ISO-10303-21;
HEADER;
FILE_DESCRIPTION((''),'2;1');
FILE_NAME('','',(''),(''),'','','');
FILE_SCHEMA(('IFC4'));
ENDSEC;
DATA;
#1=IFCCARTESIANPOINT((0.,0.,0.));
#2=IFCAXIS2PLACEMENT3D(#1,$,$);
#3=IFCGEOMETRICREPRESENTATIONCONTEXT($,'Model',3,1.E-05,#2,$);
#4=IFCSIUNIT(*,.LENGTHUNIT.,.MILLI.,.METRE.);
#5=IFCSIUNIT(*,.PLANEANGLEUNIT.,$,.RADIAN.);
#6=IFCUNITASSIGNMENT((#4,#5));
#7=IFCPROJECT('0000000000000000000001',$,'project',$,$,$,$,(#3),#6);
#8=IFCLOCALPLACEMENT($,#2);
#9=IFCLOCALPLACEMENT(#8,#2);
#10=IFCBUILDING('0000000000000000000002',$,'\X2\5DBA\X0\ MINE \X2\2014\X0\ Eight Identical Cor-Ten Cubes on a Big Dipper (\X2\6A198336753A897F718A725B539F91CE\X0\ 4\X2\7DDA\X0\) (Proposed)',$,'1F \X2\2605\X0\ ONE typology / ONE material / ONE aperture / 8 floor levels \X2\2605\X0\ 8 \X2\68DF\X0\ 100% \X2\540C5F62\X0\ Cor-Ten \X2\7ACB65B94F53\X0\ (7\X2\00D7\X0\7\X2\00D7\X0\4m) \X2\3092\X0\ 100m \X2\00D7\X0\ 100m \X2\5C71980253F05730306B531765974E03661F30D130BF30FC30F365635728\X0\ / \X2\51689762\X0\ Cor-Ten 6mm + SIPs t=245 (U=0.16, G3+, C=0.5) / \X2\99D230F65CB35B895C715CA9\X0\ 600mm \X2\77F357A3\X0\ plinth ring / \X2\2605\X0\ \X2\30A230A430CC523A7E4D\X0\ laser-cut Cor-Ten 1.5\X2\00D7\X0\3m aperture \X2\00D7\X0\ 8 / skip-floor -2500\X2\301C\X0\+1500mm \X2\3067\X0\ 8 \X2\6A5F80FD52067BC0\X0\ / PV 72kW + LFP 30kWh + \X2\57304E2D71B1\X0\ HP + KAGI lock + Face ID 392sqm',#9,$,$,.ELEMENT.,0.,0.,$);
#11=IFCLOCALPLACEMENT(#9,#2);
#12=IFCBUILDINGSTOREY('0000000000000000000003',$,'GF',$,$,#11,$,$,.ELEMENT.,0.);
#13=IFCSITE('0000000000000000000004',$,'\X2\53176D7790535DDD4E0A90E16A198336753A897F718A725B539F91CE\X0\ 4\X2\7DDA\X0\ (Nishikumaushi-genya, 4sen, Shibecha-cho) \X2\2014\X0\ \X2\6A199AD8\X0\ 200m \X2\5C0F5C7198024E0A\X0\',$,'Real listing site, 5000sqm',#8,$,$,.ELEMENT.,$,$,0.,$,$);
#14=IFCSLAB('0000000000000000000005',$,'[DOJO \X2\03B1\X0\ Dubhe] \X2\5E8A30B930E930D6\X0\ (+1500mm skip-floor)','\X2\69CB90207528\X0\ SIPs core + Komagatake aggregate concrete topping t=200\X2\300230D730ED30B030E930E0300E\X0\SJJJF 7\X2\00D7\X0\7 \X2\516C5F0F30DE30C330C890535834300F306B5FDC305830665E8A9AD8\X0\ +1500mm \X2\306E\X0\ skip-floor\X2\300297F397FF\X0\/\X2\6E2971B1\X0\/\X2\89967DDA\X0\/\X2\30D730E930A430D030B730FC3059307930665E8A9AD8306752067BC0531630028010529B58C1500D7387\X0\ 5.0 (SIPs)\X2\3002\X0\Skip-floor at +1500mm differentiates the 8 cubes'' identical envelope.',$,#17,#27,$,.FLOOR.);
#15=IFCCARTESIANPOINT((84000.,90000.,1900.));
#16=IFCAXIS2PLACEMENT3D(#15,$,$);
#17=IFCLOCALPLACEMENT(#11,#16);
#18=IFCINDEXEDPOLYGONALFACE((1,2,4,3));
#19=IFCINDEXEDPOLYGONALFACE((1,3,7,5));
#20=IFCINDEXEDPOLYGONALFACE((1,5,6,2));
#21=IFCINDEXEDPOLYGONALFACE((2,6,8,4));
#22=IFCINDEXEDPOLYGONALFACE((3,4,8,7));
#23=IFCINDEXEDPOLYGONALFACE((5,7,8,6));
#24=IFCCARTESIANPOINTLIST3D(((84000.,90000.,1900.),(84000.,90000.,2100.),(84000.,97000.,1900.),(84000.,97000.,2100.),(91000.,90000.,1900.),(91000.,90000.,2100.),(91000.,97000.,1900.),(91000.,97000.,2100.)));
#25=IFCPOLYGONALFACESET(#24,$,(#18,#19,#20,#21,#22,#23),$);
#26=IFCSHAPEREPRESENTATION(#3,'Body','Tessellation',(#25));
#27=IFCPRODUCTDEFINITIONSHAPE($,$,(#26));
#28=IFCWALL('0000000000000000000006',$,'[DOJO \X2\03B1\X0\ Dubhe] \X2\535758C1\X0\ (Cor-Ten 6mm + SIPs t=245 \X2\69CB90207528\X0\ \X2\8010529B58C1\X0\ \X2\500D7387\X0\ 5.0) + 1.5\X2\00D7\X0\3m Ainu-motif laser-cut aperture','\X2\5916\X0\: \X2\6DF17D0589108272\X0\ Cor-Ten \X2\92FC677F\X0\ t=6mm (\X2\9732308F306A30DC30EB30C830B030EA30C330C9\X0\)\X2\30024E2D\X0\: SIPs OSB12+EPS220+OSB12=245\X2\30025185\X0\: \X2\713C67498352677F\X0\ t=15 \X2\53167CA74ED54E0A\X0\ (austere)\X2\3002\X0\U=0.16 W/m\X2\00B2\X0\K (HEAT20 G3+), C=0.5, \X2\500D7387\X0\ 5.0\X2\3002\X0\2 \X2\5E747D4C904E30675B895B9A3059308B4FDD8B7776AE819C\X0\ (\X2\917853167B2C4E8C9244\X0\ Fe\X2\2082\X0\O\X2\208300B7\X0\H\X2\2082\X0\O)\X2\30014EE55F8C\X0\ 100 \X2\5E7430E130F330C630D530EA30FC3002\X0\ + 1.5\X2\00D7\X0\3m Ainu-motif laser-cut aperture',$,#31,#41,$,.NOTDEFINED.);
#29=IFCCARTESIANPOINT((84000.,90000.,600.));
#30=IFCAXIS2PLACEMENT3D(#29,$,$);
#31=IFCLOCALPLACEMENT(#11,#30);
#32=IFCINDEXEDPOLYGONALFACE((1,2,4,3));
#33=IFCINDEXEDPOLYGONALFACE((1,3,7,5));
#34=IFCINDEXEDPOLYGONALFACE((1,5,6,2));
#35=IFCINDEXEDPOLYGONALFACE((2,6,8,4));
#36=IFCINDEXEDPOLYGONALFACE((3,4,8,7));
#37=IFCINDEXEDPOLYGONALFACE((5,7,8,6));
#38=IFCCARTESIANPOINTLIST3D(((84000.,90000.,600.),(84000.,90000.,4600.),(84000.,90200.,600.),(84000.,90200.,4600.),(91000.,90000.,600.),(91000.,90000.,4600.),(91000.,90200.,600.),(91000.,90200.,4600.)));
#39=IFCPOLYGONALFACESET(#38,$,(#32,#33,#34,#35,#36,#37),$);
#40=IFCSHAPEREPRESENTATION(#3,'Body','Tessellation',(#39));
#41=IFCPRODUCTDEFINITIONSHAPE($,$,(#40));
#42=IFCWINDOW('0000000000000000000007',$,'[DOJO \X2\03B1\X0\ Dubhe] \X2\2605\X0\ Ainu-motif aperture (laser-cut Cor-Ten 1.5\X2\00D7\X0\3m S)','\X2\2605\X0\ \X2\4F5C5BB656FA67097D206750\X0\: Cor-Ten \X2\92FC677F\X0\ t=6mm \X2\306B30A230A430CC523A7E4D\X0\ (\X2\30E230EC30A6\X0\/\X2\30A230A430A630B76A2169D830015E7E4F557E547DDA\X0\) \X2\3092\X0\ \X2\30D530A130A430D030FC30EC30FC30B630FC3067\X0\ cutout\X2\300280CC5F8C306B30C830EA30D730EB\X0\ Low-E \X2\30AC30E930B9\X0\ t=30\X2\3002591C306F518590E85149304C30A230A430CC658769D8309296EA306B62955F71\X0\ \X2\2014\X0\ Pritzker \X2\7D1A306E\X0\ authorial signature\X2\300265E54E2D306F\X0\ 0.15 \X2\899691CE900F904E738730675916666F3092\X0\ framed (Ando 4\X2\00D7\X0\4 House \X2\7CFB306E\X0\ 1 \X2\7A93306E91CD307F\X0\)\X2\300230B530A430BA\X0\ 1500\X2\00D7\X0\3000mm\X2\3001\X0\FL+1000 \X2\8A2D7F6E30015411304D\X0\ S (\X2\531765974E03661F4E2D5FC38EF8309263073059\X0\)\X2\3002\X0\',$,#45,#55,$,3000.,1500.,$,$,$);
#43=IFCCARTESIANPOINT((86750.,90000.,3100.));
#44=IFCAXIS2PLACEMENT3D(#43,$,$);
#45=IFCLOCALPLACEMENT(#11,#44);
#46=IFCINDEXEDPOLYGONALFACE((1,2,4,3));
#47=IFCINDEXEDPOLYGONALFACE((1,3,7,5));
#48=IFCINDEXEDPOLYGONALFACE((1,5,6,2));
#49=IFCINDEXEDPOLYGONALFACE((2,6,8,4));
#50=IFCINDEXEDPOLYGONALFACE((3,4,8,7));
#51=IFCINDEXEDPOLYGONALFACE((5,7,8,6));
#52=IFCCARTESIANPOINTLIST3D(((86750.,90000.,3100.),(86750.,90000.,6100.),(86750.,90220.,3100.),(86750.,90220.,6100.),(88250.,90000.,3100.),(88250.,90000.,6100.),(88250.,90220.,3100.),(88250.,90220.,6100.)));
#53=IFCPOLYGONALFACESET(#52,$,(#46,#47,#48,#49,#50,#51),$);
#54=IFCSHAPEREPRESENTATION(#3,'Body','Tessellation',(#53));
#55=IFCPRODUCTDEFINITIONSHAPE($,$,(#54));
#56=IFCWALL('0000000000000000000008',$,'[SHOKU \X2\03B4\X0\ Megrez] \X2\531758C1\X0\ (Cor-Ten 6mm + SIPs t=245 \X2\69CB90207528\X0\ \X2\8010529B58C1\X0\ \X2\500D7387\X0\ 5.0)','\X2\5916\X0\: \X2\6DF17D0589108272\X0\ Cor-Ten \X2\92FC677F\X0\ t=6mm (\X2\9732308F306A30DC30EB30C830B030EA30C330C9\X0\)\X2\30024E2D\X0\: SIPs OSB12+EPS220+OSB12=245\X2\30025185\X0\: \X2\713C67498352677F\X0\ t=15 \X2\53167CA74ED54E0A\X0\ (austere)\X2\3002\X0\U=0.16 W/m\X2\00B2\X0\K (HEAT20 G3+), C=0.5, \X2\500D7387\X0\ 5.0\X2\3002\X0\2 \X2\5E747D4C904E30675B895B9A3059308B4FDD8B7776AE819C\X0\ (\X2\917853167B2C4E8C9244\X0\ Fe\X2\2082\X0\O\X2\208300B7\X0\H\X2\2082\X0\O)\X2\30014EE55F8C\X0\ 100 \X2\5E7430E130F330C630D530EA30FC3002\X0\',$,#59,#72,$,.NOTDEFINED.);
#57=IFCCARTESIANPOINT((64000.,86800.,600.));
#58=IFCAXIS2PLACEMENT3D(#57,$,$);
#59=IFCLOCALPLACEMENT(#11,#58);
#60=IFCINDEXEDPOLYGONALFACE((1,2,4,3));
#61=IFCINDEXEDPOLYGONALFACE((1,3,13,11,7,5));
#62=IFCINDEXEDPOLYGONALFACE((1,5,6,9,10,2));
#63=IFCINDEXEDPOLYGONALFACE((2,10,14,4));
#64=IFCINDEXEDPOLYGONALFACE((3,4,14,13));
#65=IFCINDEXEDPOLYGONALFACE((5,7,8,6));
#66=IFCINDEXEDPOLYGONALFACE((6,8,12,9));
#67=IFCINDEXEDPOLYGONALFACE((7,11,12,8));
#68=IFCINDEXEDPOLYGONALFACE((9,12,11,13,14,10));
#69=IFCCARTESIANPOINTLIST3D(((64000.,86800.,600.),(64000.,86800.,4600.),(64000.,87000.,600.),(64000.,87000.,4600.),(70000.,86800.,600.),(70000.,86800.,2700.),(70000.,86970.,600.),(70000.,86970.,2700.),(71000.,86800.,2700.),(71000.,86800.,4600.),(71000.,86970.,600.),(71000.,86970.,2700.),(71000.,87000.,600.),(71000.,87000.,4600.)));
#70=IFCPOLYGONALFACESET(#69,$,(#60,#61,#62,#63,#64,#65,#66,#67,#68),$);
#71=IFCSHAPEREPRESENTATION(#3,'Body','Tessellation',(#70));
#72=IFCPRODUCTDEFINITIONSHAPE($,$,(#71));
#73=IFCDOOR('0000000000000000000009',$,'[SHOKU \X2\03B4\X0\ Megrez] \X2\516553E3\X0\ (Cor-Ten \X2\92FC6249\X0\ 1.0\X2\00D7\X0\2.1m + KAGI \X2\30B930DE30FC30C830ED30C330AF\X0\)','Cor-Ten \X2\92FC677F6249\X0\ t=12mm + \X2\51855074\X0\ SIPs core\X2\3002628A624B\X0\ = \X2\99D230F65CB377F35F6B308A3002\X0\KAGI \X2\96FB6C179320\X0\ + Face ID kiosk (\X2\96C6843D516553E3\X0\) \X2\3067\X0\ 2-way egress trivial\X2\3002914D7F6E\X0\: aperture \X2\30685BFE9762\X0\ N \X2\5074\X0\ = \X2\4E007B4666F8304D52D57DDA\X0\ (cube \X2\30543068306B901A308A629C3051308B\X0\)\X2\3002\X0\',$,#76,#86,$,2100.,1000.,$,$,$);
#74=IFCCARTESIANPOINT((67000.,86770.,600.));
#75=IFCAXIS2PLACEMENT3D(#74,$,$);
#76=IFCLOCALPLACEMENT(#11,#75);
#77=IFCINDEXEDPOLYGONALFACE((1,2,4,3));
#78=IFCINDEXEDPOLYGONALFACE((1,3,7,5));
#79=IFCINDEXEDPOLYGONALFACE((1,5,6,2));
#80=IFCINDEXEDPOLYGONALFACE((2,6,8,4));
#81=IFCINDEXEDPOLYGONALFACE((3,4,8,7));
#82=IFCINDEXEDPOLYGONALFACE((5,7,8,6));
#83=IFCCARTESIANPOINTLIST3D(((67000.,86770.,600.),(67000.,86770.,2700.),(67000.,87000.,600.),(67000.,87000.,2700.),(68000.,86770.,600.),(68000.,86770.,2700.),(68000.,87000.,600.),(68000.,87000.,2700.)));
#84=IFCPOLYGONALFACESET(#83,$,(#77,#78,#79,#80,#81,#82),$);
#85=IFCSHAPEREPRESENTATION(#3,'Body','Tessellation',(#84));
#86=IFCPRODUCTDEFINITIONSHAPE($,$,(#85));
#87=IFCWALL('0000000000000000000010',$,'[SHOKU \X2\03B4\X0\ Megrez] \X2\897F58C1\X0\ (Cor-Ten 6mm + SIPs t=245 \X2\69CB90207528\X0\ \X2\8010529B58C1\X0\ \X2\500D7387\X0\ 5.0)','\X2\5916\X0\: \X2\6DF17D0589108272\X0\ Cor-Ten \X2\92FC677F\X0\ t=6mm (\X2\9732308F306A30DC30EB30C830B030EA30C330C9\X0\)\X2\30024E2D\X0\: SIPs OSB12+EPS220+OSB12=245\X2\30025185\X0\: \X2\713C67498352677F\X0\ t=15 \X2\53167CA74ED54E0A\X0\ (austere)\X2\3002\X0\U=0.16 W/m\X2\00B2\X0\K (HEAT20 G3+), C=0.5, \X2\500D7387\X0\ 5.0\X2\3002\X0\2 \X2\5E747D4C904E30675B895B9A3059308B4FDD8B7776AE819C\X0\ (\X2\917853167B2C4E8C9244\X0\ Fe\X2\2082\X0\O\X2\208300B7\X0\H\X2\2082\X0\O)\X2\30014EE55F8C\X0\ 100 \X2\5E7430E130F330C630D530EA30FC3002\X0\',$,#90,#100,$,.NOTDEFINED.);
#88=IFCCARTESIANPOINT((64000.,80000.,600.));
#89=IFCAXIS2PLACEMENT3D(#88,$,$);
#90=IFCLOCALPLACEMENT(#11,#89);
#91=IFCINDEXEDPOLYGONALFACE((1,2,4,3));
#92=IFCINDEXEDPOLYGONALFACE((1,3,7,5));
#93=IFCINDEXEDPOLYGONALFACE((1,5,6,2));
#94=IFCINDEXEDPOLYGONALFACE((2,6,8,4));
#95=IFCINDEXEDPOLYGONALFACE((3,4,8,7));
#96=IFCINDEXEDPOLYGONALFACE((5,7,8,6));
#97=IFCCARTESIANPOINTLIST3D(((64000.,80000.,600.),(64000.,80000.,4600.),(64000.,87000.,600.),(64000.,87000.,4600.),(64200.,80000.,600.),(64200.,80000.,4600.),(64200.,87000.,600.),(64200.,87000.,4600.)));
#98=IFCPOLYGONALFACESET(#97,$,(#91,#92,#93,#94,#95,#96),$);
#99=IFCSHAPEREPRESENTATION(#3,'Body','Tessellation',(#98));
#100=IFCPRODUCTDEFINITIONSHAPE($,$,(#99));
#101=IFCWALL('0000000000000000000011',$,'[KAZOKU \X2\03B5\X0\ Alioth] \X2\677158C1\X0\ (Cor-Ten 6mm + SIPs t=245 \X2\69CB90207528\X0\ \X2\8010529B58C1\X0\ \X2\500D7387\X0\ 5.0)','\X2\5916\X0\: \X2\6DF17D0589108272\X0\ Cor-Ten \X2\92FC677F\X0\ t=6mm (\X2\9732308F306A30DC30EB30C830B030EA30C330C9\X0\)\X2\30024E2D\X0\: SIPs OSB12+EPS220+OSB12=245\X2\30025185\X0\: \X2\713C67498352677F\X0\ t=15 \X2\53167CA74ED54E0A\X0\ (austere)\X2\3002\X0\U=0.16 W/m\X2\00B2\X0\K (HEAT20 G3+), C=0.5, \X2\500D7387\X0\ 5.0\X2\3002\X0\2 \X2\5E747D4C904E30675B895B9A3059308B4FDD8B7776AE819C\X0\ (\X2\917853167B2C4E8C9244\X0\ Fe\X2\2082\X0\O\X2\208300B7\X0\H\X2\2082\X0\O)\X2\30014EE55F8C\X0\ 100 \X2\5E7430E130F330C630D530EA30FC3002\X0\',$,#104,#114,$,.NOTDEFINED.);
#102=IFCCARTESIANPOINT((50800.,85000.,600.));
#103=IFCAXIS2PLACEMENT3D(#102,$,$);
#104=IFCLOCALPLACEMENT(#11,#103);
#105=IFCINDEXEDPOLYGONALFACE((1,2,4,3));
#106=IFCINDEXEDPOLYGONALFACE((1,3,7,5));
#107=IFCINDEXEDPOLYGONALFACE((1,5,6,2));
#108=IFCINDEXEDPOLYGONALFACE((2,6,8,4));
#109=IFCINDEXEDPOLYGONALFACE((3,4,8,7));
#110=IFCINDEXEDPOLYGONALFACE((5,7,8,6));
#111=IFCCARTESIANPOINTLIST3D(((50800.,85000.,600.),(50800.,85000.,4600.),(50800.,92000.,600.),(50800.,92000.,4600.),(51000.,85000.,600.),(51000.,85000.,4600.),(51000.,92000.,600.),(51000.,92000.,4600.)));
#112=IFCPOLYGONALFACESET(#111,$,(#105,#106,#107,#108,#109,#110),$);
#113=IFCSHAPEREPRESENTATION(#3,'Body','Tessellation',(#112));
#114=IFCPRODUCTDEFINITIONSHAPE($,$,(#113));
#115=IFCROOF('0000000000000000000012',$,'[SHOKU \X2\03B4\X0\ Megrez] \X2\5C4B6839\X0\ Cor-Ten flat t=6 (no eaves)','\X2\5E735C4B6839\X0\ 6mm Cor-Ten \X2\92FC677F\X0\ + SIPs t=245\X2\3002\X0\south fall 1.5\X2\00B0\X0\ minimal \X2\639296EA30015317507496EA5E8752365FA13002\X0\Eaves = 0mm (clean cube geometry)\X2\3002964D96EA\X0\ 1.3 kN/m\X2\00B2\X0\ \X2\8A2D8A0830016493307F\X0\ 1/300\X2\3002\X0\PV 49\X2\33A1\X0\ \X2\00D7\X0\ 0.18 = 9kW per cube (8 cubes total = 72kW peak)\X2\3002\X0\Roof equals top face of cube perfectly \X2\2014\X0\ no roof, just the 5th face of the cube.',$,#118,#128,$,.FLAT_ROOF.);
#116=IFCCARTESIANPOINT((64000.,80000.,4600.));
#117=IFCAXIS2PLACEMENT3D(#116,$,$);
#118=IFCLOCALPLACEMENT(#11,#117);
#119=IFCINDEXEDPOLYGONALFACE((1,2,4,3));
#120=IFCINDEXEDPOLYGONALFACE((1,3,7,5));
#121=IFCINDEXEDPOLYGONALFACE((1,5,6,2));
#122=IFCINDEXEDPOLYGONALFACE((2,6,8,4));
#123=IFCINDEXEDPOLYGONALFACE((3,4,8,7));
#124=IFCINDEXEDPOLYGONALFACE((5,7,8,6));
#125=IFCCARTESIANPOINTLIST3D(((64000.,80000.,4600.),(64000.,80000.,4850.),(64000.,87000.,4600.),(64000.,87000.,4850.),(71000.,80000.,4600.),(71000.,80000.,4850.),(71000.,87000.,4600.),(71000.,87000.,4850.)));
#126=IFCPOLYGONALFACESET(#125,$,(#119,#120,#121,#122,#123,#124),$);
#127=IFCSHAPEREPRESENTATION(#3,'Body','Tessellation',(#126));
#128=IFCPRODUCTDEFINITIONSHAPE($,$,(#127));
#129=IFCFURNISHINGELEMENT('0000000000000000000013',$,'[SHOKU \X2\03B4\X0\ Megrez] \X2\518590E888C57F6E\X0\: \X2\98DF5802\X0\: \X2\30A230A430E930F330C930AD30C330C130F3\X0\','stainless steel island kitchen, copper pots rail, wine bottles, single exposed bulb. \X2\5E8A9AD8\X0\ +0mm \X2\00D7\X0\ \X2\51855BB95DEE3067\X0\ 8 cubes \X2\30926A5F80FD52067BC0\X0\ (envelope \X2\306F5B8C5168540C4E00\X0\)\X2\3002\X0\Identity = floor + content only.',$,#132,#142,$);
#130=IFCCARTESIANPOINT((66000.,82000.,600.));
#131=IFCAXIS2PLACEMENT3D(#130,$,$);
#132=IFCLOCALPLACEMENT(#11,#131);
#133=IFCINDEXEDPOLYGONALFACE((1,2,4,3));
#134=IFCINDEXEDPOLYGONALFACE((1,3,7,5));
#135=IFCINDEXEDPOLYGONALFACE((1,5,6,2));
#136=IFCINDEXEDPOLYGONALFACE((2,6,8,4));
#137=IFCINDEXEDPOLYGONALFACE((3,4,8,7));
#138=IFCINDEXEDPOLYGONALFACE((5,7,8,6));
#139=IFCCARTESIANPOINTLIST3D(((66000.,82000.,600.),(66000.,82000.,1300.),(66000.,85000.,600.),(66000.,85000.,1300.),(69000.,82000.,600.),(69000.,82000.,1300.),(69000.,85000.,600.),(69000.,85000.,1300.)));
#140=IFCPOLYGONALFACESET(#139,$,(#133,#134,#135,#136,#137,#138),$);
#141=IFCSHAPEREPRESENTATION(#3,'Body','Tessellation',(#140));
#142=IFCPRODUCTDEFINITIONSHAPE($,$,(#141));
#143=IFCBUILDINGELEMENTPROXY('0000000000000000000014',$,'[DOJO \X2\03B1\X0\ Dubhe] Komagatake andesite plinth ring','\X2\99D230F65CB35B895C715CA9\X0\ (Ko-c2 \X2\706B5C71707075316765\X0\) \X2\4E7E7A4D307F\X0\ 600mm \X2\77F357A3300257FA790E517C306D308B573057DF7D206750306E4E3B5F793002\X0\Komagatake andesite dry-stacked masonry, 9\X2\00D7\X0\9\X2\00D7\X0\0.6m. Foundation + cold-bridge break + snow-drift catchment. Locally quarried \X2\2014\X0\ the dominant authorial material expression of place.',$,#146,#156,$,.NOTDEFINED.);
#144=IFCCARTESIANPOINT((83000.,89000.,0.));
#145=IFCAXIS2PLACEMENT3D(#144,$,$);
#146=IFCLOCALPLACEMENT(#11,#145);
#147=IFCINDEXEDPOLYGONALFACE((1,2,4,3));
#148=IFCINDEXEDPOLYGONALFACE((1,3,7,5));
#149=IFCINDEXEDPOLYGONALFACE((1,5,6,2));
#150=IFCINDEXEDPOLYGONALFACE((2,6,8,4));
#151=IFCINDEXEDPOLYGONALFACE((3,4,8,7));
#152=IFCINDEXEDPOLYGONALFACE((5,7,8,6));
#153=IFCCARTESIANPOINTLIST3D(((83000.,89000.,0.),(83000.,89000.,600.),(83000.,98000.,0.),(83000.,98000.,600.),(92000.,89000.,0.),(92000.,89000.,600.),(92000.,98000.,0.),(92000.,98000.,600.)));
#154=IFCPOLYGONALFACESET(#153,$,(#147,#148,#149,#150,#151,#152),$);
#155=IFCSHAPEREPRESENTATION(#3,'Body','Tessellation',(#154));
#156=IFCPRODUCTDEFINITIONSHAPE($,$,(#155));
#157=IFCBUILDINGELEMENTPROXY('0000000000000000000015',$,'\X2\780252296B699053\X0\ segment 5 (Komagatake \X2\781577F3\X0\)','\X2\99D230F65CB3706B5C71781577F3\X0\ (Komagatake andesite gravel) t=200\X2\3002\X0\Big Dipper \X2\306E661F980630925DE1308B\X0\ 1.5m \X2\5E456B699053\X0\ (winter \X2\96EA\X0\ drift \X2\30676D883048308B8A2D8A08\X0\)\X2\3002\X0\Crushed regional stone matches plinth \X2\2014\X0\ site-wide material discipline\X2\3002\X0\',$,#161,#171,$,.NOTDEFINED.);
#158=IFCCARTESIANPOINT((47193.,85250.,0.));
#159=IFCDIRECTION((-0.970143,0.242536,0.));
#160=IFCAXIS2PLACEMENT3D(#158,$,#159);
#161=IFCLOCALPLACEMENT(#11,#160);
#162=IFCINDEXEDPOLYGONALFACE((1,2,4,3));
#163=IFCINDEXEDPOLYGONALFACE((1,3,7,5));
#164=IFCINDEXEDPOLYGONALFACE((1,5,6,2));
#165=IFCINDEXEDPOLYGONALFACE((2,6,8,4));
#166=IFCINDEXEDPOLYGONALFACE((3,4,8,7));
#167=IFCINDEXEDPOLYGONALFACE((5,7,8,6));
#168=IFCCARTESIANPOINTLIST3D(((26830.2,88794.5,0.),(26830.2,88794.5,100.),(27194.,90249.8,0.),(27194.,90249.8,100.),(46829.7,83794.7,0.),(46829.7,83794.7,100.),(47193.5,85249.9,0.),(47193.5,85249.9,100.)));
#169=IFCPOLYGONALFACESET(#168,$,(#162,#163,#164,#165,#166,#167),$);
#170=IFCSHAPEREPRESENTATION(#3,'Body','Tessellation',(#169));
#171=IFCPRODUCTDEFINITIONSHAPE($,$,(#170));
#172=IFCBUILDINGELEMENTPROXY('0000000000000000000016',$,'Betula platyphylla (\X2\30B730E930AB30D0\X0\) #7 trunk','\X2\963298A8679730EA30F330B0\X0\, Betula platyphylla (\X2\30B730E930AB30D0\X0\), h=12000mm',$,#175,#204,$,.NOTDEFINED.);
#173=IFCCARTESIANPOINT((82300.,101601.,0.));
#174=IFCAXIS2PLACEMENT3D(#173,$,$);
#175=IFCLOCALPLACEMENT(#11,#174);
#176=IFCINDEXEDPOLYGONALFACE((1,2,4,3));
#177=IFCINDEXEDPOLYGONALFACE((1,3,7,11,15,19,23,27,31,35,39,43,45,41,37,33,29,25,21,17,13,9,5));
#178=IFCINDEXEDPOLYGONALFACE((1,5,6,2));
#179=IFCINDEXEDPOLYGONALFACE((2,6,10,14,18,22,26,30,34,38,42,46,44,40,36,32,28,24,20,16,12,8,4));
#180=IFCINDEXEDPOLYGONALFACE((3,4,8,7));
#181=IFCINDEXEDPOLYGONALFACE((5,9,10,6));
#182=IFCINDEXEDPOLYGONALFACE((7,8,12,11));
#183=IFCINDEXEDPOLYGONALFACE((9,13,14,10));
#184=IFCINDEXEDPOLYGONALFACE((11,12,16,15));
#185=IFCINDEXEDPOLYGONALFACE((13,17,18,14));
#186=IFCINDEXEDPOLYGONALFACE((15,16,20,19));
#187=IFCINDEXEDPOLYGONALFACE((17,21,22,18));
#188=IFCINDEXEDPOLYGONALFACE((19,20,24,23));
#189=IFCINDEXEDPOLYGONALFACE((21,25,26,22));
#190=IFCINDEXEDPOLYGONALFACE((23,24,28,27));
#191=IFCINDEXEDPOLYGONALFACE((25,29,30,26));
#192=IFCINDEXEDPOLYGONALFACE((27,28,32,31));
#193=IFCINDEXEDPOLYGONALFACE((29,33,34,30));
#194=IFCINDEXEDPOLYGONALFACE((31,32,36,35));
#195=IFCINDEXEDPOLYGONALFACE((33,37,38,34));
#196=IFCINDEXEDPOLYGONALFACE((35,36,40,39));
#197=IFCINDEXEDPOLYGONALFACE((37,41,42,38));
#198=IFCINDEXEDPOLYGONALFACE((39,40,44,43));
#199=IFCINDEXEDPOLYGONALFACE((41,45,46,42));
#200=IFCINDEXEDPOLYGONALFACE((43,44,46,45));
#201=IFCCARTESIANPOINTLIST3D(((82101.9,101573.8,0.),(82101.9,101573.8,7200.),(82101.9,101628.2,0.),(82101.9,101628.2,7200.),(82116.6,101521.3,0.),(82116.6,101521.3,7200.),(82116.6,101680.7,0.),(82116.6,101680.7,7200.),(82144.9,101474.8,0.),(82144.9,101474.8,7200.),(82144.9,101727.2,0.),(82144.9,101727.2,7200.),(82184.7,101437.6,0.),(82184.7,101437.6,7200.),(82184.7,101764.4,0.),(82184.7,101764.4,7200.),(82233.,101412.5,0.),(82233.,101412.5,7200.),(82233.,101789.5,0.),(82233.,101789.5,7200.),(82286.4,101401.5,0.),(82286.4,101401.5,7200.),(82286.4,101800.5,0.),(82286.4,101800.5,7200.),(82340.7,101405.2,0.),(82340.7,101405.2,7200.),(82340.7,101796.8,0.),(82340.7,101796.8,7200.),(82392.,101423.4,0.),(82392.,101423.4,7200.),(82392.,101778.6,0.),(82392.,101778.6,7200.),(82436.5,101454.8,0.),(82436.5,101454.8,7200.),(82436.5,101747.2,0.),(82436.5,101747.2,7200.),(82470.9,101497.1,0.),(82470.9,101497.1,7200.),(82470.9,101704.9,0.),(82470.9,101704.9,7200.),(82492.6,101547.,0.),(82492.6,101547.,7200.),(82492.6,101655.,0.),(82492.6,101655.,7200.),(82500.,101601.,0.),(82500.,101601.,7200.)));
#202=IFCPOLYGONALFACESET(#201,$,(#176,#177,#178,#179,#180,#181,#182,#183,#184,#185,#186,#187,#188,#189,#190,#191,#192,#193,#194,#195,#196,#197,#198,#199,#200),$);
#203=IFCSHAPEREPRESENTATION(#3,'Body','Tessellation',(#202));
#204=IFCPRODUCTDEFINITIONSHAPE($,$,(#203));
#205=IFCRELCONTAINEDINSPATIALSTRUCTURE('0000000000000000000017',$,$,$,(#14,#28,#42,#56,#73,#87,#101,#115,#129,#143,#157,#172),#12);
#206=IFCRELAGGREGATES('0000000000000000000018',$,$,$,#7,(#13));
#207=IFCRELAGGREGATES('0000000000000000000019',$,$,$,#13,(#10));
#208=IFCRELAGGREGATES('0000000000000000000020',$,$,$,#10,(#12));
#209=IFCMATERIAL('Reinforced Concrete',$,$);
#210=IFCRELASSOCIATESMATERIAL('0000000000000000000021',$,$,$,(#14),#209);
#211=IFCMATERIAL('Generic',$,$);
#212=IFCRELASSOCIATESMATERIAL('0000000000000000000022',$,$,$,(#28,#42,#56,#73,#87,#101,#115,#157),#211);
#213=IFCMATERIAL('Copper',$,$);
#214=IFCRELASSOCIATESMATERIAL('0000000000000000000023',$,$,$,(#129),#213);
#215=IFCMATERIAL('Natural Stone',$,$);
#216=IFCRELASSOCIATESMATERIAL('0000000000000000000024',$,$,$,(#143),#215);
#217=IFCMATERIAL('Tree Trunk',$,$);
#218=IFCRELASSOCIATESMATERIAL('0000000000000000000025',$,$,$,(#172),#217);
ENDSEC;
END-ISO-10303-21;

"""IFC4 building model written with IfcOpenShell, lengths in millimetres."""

from ifc_helpers import new_model, si_unit, frame, frame_2d, origin, origin_2d, place, context, project, spatial, rectangle, circle, extrude, material, element, fill, save


model = new_model("IFC4")

# Units and contexts
model_context = context("Model", 3, precision=1e-05, world=origin())
ifc_project = project(units=[si_unit("LENGTHUNIT", "METRE", prefix="MILLI"), si_unit("PLANEANGLEUNIT", "RADIAN")], contexts=[model_context])

# Site, building, storey
site_placement = place(None, origin())
site = spatial("IfcSite", under=ifc_project, at=site_placement, Name="北海道川上郡標茶町西熊牛原野 4線 (Nishikumaushi-genya, 4sen, Shibecha-cho) — 標高 200m 小山頂上", ObjectType="Real listing site, 5000sqm", CompositionType="ELEMENT", RefElevation=0.0)
building_placement = place(site_placement, origin())
building = spatial("IfcBuilding", under=site, at=building_placement, Name="嶺 MINE — Eight Identical Cor-Ten Cubes on a Big Dipper (標茶町西熊牛原野 4線) (Proposed)", ObjectType="1F ★ ONE typology / ONE material / ONE aperture / 8 floor levels ★ 8 棟 100% 同形 Cor-Ten 立方体 (7×7×4m) を 100m × 100m 山頂台地に北斗七星パターン散在 / 全面 Cor-Ten 6mm + SIPs t=245 (U=0.16, G3+, C=0.5) / 駒ヶ岳安山岩 600mm 石垣 plinth ring / ★ アイヌ刺繍 laser-cut Cor-Ten 1.5×3m aperture × 8 / skip-floor -2500〜+1500mm で 8 機能分節 / PV 72kW + LFP 30kWh + 地中熱 HP + KAGI lock + Face ID 392sqm", CompositionType="ELEMENT", ElevationOfRefHeight=0.0, ElevationOfTerrain=0.0)
storey_placement = place(building_placement, origin())
storey = spatial("IfcBuildingStorey", under=building, at=storey_placement, Name="GF", CompositionType="ELEMENT", Elevation=0.0)

# Slab
ifc_material_1 = material(Name="Reinforced Concrete")
slab_placement = place(storey_placement, frame((84000.0, 90000.0, 1900.0)))
element("IfcSlab", 1, at=slab_placement, inside=storey, material=ifc_material_1, Name="[DOJO α Dubhe] 床スラブ (+1500mm skip-floor)", Description="構造用 SIPs core + Komagatake aggregate concrete topping t=200。プログラム『SJJJF 7×7 公式マット道場』に応じて床高 +1500mm の skip-floor。音響/温熱/視線/プライバシーすべて床高で分節化。耐力壁倍率 5.0 (SIPs)。Skip-floor at +1500mm differentiates the 8 cubes' identical envelope.", PredefinedType="FLOOR", context=model_context, shape_type="SweptSolid", body=[
    extrude(rectangle(XDim=7000.0, YDim=7000.0, at=frame_2d((3500.0, 3500.0))), frame((84000.0, 90000.0, 1900.0)), (0.0, 0.0, 1.0), 200.0),
])

# Wall, opening, window
ifc_material_2 = material(Name="Generic")
wall_1_placement = place(storey_placement, frame((84000.0, 90000.0, 600.0)))
wall_1 = element("IfcWall", 2, at=wall_1_placement, inside=storey, material=ifc_material_2, Name="[DOJO α Dubhe] 南壁 (Cor-Ten 6mm + SIPs t=245 構造用 耐力壁 倍率 5.0) + 1.5×3m Ainu-motif laser-cut aperture", Description="外: 深紅褐色 Cor-Ten 鋼板 t=6mm (露わなボルトグリッド)。中: SIPs OSB12+EPS220+OSB12=245。内: 焼杉荒板 t=15 化粧仕上 (austere)。U=0.16 W/m²K (HEAT20 G3+), C=0.5, 倍率 5.0。2 年経過で安定する保護皮膜 (酸化第二鉄 Fe₂O₃·H₂O)、以後 100 年メンテフリー。 + 1.5×3m Ainu-motif laser-cut aperture", PredefinedType="NOTDEFINED", context=model_context, shape_type="SweptSolid", body=[
    extrude(rectangle(XDim=7000.0, YDim=200.0, at=frame_2d((3500.0, 100.0))), frame((84000.0, 90000.0, 600.0)), (0.0, 0.0, 1.0), 4000.0),
])
opening_1_placement = place(storey_placement, frame((86750.0, 90000.0, 3100.0)))
opening_1 = element("IfcOpeningElement", 3, at=opening_1_placement, cuts=wall_1, PredefinedType="NOTDEFINED", context=model_context, shape_type="SweptSolid", body=[
    extrude(rectangle(XDim=1500.0, YDim=220.0, at=frame_2d((750.0, 110.0))), frame((86750.0, 90000.0, 3100.0)), (0.0, 0.0, 1.0), 3000.0),
])
window_placement = place(storey_placement, frame((86750.0, 90000.0, 3100.0)))
window = element("IfcWindow", 4, at=window_placement, inside=storey, material=ifc_material_2, Name="[DOJO α Dubhe] ★ Ainu-motif aperture (laser-cut Cor-Ten 1.5×3m S)", Description="★ 作家固有素材: Cor-Ten 鋼板 t=6mm にアイヌ刺繍 (モレウ/アイウシ模様、幾何織線) を ファイバーレーザーで cutout。背後にトリプル Low-E ガラス t=30。夜は内部光がアイヌ文様を雪に投影 — Pritzker 級の authorial signature。日中は 0.15 視野透過率で外景を framed (Ando 4×4 House 系の 1 窓の重み)。サイズ 1500×3000mm、FL+1000 設置、向き S (北斗七星中心軸を指す)。", OverallHeight=3000.0, OverallWidth=1500.0, context=model_context, shape_type="SweptSolid", body=[
    extrude(rectangle(XDim=1500.0, YDim=220.0, at=frame_2d((750.0, 110.0))), frame((86750.0, 90000.0, 3100.0)), (0.0, 0.0, 1.0), 3000.0),
])
fill(opening_1, window)

# Wall, opening, door
wall_2_placement = place(storey_placement, frame((64000.0, 86800.0, 600.0)))
wall_2 = element("IfcWall", 5, at=wall_2_placement, inside=storey, material=ifc_material_2, Name="[SHOKU δ Megrez] 北壁 (Cor-Ten 6mm + SIPs t=245 構造用 耐力壁 倍率 5.0)", Description="外: 深紅褐色 Cor-Ten 鋼板 t=6mm (露わなボルトグリッド)。中: SIPs OSB12+EPS220+OSB12=245。内: 焼杉荒板 t=15 化粧仕上 (austere)。U=0.16 W/m²K (HEAT20 G3+), C=0.5, 倍率 5.0。2 年経過で安定する保護皮膜 (酸化第二鉄 Fe₂O₃·H₂O)、以後 100 年メンテフリー。", PredefinedType="NOTDEFINED", context=model_context, shape_type="SweptSolid", body=[
    extrude(rectangle(XDim=7000.0, YDim=200.0, at=frame_2d((3500.0, 100.0))), frame((64000.0, 86800.0, 600.0)), (0.0, 0.0, 1.0), 4000.0),
])
opening_2_placement = place(storey_placement, frame((67000.0, 86770.0, 600.0)))
opening_2 = element("IfcOpeningElement", 6, at=opening_2_placement, cuts=wall_2, PredefinedType="NOTDEFINED", context=model_context, shape_type="SweptSolid", body=[
    extrude(rectangle(XDim=1000.0, YDim=230.0, at=frame_2d((500.0, 115.0))), frame((67000.0, 86770.0, 600.0)), (0.0, 0.0, 1.0), 2100.0),
])
door_placement = place(storey_placement, frame((67000.0, 86770.0, 600.0)))
door = element("IfcDoor", 7, at=door_placement, inside=storey, material=ifc_material_2, Name="[SHOKU δ Megrez] 入口 (Cor-Ten 鋼扉 1.0×2.1m + KAGI スマートロック)", Description="Cor-Ten 鋼板扉 t=12mm + 内側 SIPs core。把手 = 駒ヶ岳石彫り。KAGI 電気錠 + Face ID kiosk (集落入口) で 2-way egress trivial。配置: aperture と対面 N 側 = 一筆書き動線 (cube ごとに通り抜ける)。", OverallHeight=2100.0, OverallWidth=1000.0, context=model_context, shape_type="SweptSolid", body=[
    extrude(rectangle(XDim=1000.0, YDim=230.0, at=frame_2d((500.0, 115.0))), frame((67000.0, 86770.0, 600.0)), (0.0, 0.0, 1.0), 2100.0),
])
fill(opening_2, door)

# Walls
wall_3_placement = place(storey_placement, frame((64000.0, 80000.0, 600.0)))
element("IfcWall", 8, at=wall_3_placement, inside=storey, material=ifc_material_2, Name="[SHOKU δ Megrez] 西壁 (Cor-Ten 6mm + SIPs t=245 構造用 耐力壁 倍率 5.0)", Description="外: 深紅褐色 Cor-Ten 鋼板 t=6mm (露わなボルトグリッド)。中: SIPs OSB12+EPS220+OSB12=245。内: 焼杉荒板 t=15 化粧仕上 (austere)。U=0.16 W/m²K (HEAT20 G3+), C=0.5, 倍率 5.0。2 年経過で安定する保護皮膜 (酸化第二鉄 Fe₂O₃·H₂O)、以後 100 年メンテフリー。", PredefinedType="NOTDEFINED", context=model_context, shape_type="SweptSolid", body=[
    extrude(rectangle(XDim=200.0, YDim=7000.0, at=frame_2d((100.0, 3500.0))), frame((64000.0, 80000.0, 600.0)), (0.0, 0.0, 1.0), 4000.0),
])
wall_4_placement = place(storey_placement, frame((50800.0, 85000.0, 600.0)))
element("IfcWall", 9, at=wall_4_placement, inside=storey, material=ifc_material_2, Name="[KAZOKU ε Alioth] 東壁 (Cor-Ten 6mm + SIPs t=245 構造用 耐力壁 倍率 5.0)", Description="外: 深紅褐色 Cor-Ten 鋼板 t=6mm (露わなボルトグリッド)。中: SIPs OSB12+EPS220+OSB12=245。内: 焼杉荒板 t=15 化粧仕上 (austere)。U=0.16 W/m²K (HEAT20 G3+), C=0.5, 倍率 5.0。2 年経過で安定する保護皮膜 (酸化第二鉄 Fe₂O₃·H₂O)、以後 100 年メンテフリー。", PredefinedType="NOTDEFINED", context=model_context, shape_type="SweptSolid", body=[
    extrude(rectangle(XDim=200.0, YDim=7000.0, at=frame_2d((100.0, 3500.0))), frame((50800.0, 85000.0, 600.0)), (0.0, 0.0, 1.0), 4000.0),
])

# Roof
roof_placement = place(storey_placement, frame((64000.0, 80000.0, 4600.0)))
element("IfcRoof", 10, at=roof_placement, inside=storey, material=ifc_material_2, Name="[SHOKU δ Megrez] 屋根 Cor-Ten flat t=6 (no eaves)", Description="平屋根 6mm Cor-Ten 鋼板 + SIPs t=245。south fall 1.5° minimal 排雪、北側雪庇制御。Eaves = 0mm (clean cube geometry)。降雪 1.3 kN/m² 設計、撓み 1/300。PV 49㎡ × 0.18 = 9kW per cube (8 cubes total = 72kW peak)。Roof equals top face of cube perfectly — no roof, just the 5th face of the cube.", PredefinedType="FLAT_ROOF", context=model_context, shape_type="SweptSolid", body=[
    extrude(rectangle(XDim=7000.0, YDim=7000.0, at=frame_2d((3500.0, 3500.0))), frame((64000.0, 80000.0, 4600.0)), (0.0, 0.0, 1.0), 250.0),
])

# Furnishing element
ifc_material_3 = material(Name="Copper")
furnishing_placement = place(storey_placement, frame((66000.0, 82000.0, 600.0)))
element("IfcFurnishingElement", 11, at=furnishing_placement, inside=storey, material=ifc_material_3, Name="[SHOKU δ Megrez] 内部装置: 食堂: アイランドキッチン", Description="stainless steel island kitchen, copper pots rail, wine bottles, single exposed bulb. 床高 +0mm × 内容差で 8 cubes を機能分節 (envelope は完全同一)。Identity = floor + content only.", context=model_context, shape_type="SweptSolid", body=[
    extrude(rectangle(XDim=3000.0, YDim=3000.0, at=frame_2d((1500.0, 1500.0))), frame((66000.0, 82000.0, 600.0)), (0.0, 0.0, 1.0), 700.0),
])

# Building element proxies
ifc_material_4 = material(Name="Natural Stone")
proxy_1_placement = place(storey_placement, frame((83000.0, 89000.0, 0.0)))
element("IfcBuildingElementProxy", 12, at=proxy_1_placement, inside=storey, material=ifc_material_4, Name="[DOJO α Dubhe] Komagatake andesite plinth ring", Description="駒ヶ岳安山岩 (Ko-c2 火山灰由来) 乾積み 600mm 石垣。基礎兼ねる地域素材の主役。Komagatake andesite dry-stacked masonry, 9×9×0.6m. Foundation + cold-bridge break + snow-drift catchment. Locally quarried — the dominant authorial material expression of place.", PredefinedType="NOTDEFINED", context=model_context, shape_type="SweptSolid", body=[
    extrude(rectangle(XDim=9000.0, YDim=9000.0, at=frame_2d((4500.0, 4500.0))), frame((83000.0, 89000.0, 0.0)), (0.0, 0.0, 1.0), 600.0),
])
proxy_2_placement = place(storey_placement, frame((47193.0, 85250.0, 0.0), x_axis=(-0.970143, 0.242536, 0.0)))
element("IfcBuildingElementProxy", 13, at=proxy_2_placement, inside=storey, material=ifc_material_2, Name="砂利歩道 segment 5 (Komagatake 砕石)", Description="駒ヶ岳火山砕石 (Komagatake andesite gravel) t=200。Big Dipper の星順を巡る 1.5m 幅歩道 (winter 雪 drift で消える設計)。Crushed regional stone matches plinth — site-wide material discipline。", PredefinedType="NOTDEFINED", context=model_context, shape_type="SweptSolid", body=[
    extrude(rectangle(XDim=20615.0, YDim=1500.0, at=frame_2d((10307.0, 750.0))), frame((47193.0, 85250.0, 0.0), x_axis=(-0.970143, 0.242536, 0.0)), (0.0, 0.0, 1.0), 100.0),
])
ifc_material_5 = material(Name="Tree Trunk")
proxy_3_placement = place(storey_placement, frame((82300.0, 101601.0, 0.0)))
element("IfcBuildingElementProxy", 14, at=proxy_3_placement, inside=storey, material=ifc_material_5, Name="Betula platyphylla (シラカバ) #7 trunk", Description="防風林リング, Betula platyphylla (シラカバ), h=12000mm", PredefinedType="NOTDEFINED", context=model_context, shape_type="SweptSolid", body=[
    extrude(circle(Radius=200.0, at=origin_2d()), frame((82300.0, 101601.0, 0.0)), (0.0, 0.0, 1.0), 7200.0),
])

save(model, "model.ifc")
